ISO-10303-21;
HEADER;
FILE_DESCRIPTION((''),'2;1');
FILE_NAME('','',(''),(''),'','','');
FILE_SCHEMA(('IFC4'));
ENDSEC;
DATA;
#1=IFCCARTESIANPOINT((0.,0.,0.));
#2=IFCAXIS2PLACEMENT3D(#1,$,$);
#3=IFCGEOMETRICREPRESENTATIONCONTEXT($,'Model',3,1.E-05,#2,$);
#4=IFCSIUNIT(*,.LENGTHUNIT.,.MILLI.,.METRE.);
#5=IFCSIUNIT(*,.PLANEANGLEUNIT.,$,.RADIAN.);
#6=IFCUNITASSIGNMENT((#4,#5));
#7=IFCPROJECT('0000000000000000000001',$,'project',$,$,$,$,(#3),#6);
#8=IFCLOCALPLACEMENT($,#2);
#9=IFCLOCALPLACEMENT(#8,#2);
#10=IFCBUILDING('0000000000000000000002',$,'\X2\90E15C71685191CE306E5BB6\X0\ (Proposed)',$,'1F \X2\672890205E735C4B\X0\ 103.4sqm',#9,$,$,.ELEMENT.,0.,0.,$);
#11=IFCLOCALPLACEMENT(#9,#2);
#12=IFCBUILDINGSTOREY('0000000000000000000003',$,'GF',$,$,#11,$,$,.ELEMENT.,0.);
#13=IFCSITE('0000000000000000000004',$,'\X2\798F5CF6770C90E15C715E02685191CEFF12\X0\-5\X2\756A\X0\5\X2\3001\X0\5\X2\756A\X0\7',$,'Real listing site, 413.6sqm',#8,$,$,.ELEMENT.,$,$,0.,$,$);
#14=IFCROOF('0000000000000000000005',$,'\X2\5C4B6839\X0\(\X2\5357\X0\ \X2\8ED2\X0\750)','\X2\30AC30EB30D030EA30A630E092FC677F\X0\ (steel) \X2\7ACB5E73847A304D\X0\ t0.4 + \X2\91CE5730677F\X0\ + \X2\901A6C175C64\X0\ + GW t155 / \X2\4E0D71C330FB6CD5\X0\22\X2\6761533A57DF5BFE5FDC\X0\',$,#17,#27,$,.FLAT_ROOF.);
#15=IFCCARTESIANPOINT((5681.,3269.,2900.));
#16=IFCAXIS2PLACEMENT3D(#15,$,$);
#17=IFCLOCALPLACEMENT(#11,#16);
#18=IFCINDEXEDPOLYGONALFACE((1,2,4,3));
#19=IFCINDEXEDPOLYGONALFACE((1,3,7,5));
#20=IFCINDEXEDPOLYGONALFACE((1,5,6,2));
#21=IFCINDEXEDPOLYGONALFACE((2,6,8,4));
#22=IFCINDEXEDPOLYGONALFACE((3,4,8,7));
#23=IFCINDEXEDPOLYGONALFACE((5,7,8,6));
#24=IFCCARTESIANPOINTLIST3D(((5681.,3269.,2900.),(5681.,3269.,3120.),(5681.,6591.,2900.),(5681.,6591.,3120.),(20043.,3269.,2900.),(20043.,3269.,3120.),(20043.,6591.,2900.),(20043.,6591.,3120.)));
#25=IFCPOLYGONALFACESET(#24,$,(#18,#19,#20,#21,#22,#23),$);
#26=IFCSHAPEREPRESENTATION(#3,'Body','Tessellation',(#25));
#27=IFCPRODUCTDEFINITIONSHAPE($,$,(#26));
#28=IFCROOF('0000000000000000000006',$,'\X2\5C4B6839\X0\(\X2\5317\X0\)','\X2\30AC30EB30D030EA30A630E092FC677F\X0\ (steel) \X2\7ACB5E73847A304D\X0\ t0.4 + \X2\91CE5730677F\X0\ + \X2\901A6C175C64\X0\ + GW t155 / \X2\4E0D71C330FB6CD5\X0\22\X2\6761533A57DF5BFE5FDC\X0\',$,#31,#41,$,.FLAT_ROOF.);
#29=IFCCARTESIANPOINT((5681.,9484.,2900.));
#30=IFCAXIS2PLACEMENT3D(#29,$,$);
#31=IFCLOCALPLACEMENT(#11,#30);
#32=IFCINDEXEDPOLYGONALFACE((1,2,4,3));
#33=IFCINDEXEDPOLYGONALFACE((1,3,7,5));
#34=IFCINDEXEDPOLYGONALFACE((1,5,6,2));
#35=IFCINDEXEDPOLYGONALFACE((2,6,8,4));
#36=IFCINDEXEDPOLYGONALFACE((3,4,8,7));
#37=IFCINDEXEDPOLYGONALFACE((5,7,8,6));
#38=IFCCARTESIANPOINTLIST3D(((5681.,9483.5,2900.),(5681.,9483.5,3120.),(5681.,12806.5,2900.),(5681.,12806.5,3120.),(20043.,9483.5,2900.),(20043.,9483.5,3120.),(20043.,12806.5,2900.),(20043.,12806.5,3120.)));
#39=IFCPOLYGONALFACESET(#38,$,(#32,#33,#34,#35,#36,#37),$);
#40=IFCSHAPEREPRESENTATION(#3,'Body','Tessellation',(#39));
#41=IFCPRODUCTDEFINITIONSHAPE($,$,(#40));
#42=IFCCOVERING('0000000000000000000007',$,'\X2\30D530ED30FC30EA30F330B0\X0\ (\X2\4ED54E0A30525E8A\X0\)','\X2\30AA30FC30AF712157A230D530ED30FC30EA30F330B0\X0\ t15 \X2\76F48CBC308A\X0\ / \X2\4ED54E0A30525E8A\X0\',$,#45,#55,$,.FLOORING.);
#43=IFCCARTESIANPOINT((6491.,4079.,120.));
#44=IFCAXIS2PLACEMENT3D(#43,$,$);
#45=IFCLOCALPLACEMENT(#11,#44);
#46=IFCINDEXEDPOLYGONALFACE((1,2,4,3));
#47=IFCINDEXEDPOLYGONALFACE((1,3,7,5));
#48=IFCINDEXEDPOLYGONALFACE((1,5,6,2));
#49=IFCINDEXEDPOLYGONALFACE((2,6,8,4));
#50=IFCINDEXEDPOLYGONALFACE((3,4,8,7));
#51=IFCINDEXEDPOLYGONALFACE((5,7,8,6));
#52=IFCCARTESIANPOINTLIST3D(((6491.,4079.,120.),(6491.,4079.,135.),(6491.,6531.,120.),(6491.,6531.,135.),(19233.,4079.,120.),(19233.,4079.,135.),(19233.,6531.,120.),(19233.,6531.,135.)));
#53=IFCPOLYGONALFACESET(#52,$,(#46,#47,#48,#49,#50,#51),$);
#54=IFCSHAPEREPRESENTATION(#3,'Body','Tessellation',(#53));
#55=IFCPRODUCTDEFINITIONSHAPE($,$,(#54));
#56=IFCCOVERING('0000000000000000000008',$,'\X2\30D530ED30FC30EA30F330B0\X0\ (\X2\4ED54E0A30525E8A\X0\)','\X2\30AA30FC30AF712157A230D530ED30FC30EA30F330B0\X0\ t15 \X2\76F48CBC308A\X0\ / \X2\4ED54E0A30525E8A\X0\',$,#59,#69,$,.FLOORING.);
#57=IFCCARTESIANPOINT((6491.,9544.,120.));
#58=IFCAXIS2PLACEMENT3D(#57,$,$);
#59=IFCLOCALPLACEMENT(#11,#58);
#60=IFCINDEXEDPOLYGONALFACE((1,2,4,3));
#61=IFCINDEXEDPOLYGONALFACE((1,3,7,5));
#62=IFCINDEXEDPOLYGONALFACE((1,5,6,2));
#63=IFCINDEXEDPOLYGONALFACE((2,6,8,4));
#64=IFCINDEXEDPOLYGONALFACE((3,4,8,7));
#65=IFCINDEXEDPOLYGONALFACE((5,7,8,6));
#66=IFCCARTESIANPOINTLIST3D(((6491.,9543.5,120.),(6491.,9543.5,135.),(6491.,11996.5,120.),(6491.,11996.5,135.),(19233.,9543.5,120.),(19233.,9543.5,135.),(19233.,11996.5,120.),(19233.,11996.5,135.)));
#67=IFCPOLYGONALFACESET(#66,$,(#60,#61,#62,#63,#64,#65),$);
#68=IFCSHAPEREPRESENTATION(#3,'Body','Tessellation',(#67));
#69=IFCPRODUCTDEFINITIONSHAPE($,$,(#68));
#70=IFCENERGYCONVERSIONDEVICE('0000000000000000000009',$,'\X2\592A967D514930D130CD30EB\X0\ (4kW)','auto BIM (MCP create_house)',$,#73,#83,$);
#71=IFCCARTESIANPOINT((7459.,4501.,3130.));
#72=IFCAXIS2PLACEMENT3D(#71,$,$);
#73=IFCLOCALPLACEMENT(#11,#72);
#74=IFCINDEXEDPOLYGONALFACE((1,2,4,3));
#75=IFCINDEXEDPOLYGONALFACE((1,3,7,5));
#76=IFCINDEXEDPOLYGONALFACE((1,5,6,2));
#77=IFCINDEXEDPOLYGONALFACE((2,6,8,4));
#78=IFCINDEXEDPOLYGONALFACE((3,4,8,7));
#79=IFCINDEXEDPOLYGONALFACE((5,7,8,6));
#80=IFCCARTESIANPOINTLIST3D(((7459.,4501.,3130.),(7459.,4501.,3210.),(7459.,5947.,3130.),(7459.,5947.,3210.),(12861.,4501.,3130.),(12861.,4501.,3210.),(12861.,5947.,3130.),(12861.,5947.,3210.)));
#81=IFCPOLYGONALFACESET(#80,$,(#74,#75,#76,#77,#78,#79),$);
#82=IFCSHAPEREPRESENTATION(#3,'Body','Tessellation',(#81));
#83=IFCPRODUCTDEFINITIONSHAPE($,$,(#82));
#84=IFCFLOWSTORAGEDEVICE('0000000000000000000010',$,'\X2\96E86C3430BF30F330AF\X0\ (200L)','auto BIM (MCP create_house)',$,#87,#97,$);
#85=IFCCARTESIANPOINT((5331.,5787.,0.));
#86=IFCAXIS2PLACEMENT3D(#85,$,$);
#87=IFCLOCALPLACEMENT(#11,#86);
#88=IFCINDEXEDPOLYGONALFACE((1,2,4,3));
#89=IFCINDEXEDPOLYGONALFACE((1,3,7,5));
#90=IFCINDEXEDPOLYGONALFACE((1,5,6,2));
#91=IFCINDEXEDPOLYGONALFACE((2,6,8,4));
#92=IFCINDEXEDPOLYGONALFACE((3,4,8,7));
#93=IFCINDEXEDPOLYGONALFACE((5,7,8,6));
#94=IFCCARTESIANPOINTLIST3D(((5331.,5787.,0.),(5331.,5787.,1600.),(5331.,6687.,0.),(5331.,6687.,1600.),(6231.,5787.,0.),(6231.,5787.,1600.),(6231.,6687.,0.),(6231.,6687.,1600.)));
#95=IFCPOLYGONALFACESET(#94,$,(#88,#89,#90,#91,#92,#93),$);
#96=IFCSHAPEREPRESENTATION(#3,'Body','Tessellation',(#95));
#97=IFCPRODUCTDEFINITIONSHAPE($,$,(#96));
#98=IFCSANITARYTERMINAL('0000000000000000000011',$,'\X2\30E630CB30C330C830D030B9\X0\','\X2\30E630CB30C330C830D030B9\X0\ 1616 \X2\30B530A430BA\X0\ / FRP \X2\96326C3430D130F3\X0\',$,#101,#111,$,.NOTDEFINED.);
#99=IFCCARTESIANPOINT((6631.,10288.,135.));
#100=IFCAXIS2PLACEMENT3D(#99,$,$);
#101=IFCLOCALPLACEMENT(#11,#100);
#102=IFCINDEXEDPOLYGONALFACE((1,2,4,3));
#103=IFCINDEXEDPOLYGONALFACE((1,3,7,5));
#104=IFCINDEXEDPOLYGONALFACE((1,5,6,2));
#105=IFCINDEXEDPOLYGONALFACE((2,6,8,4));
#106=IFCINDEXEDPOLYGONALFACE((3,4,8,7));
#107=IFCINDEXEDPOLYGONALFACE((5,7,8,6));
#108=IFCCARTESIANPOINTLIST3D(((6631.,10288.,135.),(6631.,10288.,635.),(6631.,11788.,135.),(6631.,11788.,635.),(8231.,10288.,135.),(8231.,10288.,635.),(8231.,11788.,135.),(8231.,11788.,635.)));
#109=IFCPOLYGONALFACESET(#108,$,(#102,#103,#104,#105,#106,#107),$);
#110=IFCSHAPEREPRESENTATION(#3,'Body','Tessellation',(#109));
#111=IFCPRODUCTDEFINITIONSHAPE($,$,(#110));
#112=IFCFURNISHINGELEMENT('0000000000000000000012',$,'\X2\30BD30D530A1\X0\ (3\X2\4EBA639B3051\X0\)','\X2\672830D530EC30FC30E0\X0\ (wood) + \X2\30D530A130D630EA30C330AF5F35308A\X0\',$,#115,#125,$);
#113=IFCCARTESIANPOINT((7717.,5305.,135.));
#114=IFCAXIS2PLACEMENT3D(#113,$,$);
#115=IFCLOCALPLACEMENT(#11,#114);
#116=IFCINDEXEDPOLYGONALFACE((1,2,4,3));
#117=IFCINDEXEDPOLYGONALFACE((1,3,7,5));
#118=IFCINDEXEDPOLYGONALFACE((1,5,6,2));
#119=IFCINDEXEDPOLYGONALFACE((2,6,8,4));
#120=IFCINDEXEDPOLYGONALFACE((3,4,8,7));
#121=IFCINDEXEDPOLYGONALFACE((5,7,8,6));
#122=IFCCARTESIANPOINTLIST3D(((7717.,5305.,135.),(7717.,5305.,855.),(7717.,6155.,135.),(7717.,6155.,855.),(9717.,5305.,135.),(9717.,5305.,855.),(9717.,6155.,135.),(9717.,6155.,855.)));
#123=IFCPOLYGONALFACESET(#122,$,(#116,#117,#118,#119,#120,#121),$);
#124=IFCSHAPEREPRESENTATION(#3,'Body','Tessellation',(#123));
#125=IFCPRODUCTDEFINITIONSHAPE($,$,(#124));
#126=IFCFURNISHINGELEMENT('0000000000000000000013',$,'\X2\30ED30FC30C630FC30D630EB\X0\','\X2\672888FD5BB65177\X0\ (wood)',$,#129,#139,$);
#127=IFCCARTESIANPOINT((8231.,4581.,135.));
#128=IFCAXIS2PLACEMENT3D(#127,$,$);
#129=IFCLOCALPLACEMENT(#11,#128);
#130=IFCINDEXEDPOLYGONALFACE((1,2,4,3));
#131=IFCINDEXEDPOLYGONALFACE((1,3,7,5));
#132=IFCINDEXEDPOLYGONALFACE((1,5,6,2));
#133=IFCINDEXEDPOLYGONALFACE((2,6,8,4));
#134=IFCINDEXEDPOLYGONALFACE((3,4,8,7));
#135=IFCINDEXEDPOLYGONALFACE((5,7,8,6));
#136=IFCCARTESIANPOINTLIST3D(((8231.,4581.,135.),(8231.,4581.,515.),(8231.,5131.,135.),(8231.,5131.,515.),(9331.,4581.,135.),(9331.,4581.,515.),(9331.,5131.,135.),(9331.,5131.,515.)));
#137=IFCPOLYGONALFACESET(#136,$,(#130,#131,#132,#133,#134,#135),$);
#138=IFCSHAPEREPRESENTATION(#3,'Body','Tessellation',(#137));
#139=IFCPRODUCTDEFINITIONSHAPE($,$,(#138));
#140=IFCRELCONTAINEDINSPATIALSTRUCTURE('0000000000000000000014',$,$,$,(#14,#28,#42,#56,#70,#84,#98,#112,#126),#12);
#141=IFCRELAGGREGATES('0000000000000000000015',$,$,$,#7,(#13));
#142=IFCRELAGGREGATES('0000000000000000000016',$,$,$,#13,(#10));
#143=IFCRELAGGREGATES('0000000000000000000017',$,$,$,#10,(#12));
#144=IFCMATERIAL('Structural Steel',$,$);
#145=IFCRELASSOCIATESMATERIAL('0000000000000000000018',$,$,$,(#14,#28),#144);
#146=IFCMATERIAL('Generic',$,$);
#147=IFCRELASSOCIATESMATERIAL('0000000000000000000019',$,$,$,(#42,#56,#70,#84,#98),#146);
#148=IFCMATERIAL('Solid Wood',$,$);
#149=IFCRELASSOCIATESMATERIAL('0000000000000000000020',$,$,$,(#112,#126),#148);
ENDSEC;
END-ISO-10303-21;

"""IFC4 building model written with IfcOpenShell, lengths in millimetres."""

from ifc_helpers import new_model, si_unit, frame, frame_2d, origin, place, context, project, spatial, rectangle, extrude, material, element, save


model = new_model("IFC4")

# Units and contexts
model_context = context("Model", 3, precision=1e-05, world=origin())
ifc_project = project(units=[si_unit("LENGTHUNIT", "METRE", prefix="MILLI"), si_unit("PLANEANGLEUNIT", "RADIAN")], contexts=[model_context])

# Site, building, storey
site_placement = place(None, origin())
site = spatial("IfcSite", under=ifc_project, at=site_placement, Name="福島県郡山市桑野２-5番5、5番7", ObjectType="Real listing site, 413.6sqm", CompositionType="ELEMENT", RefElevation=0.0)
building_placement = place(site_placement, origin())
building = spatial("IfcBuilding", under=site, at=building_placement, Name="郡山桑野の家 (Proposed)", ObjectType="1F 木造平屋 103.4sqm", CompositionType="ELEMENT", ElevationOfRefHeight=0.0, ElevationOfTerrain=0.0)
storey_placement = place(building_placement, origin())
storey = spatial("IfcBuildingStorey", under=building, at=storey_placement, Name="GF", CompositionType="ELEMENT", Elevation=0.0)

# Shared definitions
ifc_material_1 = material(Name="Solid Wood")

# Roofs
ifc_material_2 = material(Name="Structural Steel")
roof_1_placement = place(storey_placement, frame((5681.0, 3269.0, 2900.0)))
element("IfcRoof", 1, at=roof_1_placement, inside=storey, material=ifc_material_2, Name="屋根(南 軒750)", Description="ガルバリウム鋼板 (steel) 立平葺き t0.4 + 野地板 + 通気層 + GW t155 / 不燃・法22条区域対応", PredefinedType="FLAT_ROOF", context=model_context, shape_type="SweptSolid", body=[
    extrude(rectangle(XDim=14362.0, YDim=3322.0, at=frame_2d((7181.0, 1661.0))), frame((5681.0, 3269.0, 2900.0)), (0.0, 0.0, 1.0), 220.0),
])
roof_2_placement = place(storey_placement, frame((5681.0, 9484.0, 2900.0)))
element("IfcRoof", 2, at=roof_2_placement, inside=storey, material=ifc_material_2, Name="屋根(北)", Description="ガルバリウム鋼板 (steel) 立平葺き t0.4 + 野地板 + 通気層 + GW t155 / 不燃・法22条区域対応", PredefinedType="FLAT_ROOF", context=model_context, shape_type="SweptSolid", body=[
    extrude(rectangle(XDim=14362.0, YDim=3323.0, at=frame_2d((7181.0, 1661.0))), frame((5681.0, 9484.0, 2900.0)), (0.0, 0.0, 1.0), 220.0),
])

# Coverings
ifc_material_3 = material(Name="Generic")
covering_1_placement = place(storey_placement, frame((6491.0, 4079.0, 120.0)))
element("IfcCovering", 3, at=covering_1_placement, inside=storey, material=ifc_material_3, Name="フローリング (仕上げ床)", Description="オーク無垢フローリング t15 直貼り / 仕上げ床", PredefinedType="FLOORING", context=model_context, shape_type="SweptSolid", body=[
    extrude(rectangle(XDim=12742.0, YDim=2452.0, at=frame_2d((6371.0, 1226.0))), frame((6491.0, 4079.0, 120.0)), (0.0, 0.0, 1.0), 15.0),
])
covering_2_placement = place(storey_placement, frame((6491.0, 9544.0, 120.0)))
element("IfcCovering", 4, at=covering_2_placement, inside=storey, material=ifc_material_3, Name="フローリング (仕上げ床)", Description="オーク無垢フローリング t15 直貼り / 仕上げ床", PredefinedType="FLOORING", context=model_context, shape_type="SweptSolid", body=[
    extrude(rectangle(XDim=12742.0, YDim=2453.0, at=frame_2d((6371.0, 1226.0))), frame((6491.0, 9544.0, 120.0)), (0.0, 0.0, 1.0), 15.0),
])

# Energy conversion device
energy_conversion_device_placement = place(storey_placement, frame((7459.0, 4501.0, 3130.0)))
element("IfcEnergyConversionDevice", 5, at=energy_conversion_device_placement, inside=storey, material=ifc_material_3, Name="太陽光パネル (4kW)", Description="auto BIM (MCP create_house)", context=model_context, shape_type="SweptSolid", body=[
    extrude(rectangle(XDim=5402.0, YDim=1446.0, at=frame_2d((2701.0, 723.0))), frame((7459.0, 4501.0, 3130.0)), (0.0, 0.0, 1.0), 80.0),
])

# Flow storage device
flow_storage_device_placement = place(storey_placement, frame((5331.0, 5787.0, 0.0)))
element("IfcFlowStorageDevice", 6, at=flow_storage_device_placement, inside=storey, material=ifc_material_3, Name="雨水タンク (200L)", Description="auto BIM (MCP create_house)", context=model_context, shape_type="SweptSolid", body=[
    extrude(rectangle(XDim=900.0, YDim=900.0, at=frame_2d((450.0, 450.0))), frame((5331.0, 5787.0, 0.0)), (0.0, 0.0, 1.0), 1600.0),
])

# Sanitary terminal
sanitary_terminal_placement = place(storey_placement, frame((6631.0, 10288.0, 135.0)))
element("IfcSanitaryTerminal", 7, at=sanitary_terminal_placement, inside=storey, material=ifc_material_3, Name="ユニットバス", Description="ユニットバス 1616 サイズ / FRP 防水パン", PredefinedType="NOTDEFINED", context=model_context, shape_type="SweptSolid", body=[
    extrude(rectangle(XDim=1600.0, YDim=1500.0, at=frame_2d((800.0, 750.0))), frame((6631.0, 10288.0, 135.0)), (0.0, 0.0, 1.0), 500.0),
])

# Furnishing elements
furnishing_1_placement = place(storey_placement, frame((7717.0, 5305.0, 135.0)))
element("IfcFurnishingElement", 8, at=furnishing_1_placement, inside=storey, material=ifc_material_1, Name="ソファ (3人掛け)", Description="木フレーム (wood) + ファブリック張り", context=model_context, shape_type="SweptSolid", body=[
    extrude(rectangle(XDim=2000.0, YDim=850.0, at=frame_2d((1000.0, 425.0))), frame((7717.0, 5305.0, 135.0)), (0.0, 0.0, 1.0), 720.0),
])
furnishing_2_placement = place(storey_placement, frame((8231.0, 4581.0, 135.0)))
element("IfcFurnishingElement", 9, at=furnishing_2_placement, inside=storey, material=ifc_material_1, Name="ローテーブル", Description="木製家具 (wood)", context=model_context, shape_type="SweptSolid", body=[
    extrude(rectangle(XDim=1100.0, YDim=550.0, at=frame_2d((550.0, 275.0))), frame((8231.0, 4581.0, 135.0)), (0.0, 0.0, 1.0), 380.0),
])

save(model, "model.ifc")
